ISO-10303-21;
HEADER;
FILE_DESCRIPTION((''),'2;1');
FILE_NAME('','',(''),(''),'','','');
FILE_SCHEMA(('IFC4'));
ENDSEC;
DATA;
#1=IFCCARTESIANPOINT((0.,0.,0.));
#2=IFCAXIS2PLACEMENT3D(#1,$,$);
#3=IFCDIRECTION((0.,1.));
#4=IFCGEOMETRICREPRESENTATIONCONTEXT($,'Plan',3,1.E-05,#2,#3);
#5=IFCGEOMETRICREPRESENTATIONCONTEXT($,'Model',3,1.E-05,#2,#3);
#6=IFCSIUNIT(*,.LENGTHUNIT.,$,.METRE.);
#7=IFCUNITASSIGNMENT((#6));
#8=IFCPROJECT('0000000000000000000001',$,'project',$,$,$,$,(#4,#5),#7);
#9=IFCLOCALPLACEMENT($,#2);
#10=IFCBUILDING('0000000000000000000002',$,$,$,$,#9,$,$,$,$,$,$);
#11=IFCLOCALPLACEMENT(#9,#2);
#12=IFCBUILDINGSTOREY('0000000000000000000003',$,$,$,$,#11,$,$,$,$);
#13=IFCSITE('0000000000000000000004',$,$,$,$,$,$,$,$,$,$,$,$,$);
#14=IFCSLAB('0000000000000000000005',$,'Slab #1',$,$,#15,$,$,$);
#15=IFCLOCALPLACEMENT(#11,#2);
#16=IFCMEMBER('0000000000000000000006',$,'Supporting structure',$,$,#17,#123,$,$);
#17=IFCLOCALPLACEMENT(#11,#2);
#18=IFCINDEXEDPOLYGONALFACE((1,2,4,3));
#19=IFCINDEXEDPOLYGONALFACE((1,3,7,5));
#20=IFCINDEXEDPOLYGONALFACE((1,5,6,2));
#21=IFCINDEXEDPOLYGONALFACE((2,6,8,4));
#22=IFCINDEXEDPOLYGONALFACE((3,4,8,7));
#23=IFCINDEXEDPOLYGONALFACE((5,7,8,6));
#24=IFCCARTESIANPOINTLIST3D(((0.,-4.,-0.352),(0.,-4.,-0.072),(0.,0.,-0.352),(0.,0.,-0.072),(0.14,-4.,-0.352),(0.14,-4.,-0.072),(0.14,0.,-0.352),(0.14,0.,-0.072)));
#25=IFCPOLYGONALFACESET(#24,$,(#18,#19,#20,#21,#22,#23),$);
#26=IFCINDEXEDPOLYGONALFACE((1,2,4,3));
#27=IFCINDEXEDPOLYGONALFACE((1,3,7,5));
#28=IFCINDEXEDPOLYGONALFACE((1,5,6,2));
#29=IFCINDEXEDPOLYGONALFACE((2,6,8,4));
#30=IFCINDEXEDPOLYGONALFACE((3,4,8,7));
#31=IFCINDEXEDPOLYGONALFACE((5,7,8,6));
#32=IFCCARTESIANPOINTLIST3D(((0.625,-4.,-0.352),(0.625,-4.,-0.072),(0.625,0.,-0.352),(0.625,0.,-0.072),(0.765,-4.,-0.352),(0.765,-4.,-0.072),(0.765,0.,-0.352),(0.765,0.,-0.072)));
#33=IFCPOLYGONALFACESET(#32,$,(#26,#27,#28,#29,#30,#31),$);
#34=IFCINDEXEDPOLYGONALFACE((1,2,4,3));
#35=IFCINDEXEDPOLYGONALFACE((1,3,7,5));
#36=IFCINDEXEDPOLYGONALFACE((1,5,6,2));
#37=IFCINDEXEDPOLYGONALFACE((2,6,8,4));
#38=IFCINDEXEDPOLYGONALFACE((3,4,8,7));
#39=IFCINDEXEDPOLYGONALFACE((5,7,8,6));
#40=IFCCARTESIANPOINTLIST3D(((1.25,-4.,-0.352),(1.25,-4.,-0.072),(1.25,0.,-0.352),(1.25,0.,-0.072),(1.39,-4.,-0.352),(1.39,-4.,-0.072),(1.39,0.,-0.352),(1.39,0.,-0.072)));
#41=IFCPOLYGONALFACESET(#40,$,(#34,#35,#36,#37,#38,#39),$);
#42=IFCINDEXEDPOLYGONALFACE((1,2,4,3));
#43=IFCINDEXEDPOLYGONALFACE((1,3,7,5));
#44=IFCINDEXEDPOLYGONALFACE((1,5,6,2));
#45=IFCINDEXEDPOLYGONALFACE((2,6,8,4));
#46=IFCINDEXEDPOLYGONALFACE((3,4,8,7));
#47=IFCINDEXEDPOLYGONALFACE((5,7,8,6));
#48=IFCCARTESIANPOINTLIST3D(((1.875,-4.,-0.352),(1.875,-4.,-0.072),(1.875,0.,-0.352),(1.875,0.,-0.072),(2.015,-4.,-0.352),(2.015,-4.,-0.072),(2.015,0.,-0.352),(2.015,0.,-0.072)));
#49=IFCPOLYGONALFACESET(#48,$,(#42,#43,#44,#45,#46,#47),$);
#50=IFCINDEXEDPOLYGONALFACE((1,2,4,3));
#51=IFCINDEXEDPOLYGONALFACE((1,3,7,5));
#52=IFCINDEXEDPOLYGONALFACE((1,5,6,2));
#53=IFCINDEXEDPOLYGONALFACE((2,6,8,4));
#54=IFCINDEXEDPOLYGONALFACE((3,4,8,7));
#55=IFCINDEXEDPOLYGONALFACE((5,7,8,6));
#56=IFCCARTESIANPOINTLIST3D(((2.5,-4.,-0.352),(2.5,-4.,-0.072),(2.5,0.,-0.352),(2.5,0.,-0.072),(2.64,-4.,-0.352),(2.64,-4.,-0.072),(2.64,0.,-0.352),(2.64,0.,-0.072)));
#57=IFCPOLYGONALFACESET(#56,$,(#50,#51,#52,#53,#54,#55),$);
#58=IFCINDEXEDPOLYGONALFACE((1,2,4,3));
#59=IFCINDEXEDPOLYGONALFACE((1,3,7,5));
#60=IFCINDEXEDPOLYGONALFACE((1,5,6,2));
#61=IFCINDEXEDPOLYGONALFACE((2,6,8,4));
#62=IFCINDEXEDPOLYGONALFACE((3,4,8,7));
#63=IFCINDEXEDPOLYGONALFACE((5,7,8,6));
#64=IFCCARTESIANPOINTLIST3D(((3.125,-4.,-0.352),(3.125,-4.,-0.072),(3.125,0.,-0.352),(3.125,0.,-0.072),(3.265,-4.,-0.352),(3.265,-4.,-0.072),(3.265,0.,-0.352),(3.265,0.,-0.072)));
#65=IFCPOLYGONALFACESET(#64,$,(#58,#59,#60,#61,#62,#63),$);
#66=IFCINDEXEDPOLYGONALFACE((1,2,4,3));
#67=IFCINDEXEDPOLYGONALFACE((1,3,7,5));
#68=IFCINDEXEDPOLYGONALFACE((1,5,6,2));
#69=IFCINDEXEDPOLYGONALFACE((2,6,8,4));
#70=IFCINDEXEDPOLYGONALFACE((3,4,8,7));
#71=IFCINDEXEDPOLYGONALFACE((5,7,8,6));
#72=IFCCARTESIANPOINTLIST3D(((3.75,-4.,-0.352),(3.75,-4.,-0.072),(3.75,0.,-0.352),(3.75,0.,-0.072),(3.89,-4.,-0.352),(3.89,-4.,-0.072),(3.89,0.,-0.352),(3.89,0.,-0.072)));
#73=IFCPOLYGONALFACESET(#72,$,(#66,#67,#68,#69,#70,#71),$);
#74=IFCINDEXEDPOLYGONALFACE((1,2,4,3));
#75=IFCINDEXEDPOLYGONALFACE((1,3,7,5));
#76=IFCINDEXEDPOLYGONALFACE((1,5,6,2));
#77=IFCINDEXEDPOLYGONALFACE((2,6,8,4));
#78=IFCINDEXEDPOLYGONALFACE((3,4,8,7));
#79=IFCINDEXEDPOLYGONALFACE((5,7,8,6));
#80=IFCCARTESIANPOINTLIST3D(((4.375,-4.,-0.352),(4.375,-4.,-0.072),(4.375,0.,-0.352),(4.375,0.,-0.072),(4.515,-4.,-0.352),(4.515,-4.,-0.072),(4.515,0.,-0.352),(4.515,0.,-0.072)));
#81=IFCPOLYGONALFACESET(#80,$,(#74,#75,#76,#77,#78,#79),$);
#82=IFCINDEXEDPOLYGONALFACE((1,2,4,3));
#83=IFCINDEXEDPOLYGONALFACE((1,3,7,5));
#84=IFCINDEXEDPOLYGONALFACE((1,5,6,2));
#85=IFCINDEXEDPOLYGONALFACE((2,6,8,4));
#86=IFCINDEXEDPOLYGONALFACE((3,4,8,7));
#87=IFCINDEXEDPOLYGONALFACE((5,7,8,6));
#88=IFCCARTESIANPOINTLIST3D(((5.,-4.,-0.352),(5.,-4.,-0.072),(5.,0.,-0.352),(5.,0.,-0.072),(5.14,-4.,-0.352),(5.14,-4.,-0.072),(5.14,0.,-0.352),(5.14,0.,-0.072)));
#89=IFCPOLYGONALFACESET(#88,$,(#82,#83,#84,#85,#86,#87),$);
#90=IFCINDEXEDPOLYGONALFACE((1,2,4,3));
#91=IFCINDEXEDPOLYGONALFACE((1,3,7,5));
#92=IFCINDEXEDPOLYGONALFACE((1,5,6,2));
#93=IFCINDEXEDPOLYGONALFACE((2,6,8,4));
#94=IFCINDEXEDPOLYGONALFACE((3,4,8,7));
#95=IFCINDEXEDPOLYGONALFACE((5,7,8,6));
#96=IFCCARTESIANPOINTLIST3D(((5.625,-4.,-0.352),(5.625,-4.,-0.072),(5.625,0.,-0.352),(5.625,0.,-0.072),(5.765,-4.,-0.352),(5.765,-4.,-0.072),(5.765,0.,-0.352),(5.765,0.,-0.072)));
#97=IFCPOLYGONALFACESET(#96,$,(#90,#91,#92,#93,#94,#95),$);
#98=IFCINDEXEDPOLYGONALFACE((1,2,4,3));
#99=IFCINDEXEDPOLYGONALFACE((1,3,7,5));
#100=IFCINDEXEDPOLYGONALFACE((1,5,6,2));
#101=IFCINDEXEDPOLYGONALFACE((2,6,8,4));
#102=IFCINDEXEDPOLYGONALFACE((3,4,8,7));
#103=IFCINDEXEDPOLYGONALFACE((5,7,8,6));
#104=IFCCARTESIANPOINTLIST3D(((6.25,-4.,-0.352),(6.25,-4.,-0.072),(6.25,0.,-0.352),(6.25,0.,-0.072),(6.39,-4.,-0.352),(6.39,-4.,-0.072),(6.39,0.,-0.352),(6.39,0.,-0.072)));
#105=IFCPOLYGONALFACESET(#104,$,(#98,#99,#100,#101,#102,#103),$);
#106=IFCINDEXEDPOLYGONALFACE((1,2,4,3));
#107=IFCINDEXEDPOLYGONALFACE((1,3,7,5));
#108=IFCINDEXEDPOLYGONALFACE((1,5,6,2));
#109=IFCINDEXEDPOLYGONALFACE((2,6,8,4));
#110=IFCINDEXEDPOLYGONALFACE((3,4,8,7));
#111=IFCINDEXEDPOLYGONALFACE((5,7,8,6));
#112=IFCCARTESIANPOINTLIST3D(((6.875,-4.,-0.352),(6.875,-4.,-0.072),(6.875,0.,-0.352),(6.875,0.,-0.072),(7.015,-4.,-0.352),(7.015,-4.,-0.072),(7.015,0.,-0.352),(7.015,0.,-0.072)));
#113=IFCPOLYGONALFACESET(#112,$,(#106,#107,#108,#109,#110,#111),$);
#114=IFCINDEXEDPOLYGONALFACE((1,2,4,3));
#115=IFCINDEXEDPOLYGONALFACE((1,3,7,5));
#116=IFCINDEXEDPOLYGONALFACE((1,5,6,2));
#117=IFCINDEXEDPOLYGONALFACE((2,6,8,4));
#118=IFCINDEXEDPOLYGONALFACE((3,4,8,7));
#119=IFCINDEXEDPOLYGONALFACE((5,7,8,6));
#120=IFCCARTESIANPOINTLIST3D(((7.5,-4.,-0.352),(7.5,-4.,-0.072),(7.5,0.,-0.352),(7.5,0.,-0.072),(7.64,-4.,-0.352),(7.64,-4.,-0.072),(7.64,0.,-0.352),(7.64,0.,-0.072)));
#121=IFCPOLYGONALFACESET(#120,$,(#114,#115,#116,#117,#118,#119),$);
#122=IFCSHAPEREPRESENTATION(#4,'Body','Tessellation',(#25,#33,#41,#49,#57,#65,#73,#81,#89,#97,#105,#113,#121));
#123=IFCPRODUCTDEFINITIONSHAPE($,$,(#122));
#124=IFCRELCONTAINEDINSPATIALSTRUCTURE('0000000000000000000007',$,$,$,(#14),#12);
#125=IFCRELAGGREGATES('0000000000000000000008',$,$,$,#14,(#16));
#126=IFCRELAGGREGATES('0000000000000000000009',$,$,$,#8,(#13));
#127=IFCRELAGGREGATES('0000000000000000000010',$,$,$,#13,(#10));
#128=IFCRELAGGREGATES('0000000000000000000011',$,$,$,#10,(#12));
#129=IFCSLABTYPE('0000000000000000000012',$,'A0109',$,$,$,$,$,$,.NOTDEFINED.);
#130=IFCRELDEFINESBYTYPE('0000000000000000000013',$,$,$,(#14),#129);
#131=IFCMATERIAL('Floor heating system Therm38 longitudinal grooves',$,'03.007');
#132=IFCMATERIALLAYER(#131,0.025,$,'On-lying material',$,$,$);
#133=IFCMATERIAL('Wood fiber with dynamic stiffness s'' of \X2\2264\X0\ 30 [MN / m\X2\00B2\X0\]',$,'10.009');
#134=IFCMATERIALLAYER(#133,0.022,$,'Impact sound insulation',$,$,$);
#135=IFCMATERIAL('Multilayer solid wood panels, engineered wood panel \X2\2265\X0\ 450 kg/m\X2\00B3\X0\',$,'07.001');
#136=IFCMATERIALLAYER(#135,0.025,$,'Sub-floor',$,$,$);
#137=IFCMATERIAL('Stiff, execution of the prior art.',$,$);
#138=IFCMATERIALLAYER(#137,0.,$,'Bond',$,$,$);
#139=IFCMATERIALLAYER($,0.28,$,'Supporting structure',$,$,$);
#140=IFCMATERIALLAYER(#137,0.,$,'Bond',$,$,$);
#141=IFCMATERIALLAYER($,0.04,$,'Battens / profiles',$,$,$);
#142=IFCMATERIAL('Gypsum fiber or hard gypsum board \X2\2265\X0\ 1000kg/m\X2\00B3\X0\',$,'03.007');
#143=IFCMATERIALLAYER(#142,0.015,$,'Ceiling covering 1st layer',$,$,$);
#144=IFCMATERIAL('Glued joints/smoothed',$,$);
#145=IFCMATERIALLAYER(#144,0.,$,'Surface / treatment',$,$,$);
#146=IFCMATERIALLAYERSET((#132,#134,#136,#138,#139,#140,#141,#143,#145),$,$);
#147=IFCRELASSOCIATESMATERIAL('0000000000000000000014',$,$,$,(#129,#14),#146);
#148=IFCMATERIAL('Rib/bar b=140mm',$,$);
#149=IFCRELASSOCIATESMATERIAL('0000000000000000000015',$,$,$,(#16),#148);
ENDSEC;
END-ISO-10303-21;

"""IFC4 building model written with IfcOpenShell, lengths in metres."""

from ifc_helpers import new_model, si_unit, direction, frame, frame_2d, origin, place, context, project, spatial, rectangle, extrude, material, layer, layer_set, type_object, element, aggregate, save


model = new_model("IFC4")

# Units and contexts
plan_context = context("Plan", 3, precision=1e-05, world=origin(), true_north=direction((0.0, 1.0)))
model_context = context("Model", 3, precision=1e-05, world=origin(), true_north=direction((0.0, 1.0)))
ifc_project = project(units=[si_unit("LENGTHUNIT", "METRE")], contexts=[plan_context, model_context])

# Site, building, storey
site = spatial("IfcSite", under=ifc_project)
building_placement = place(None, origin())
building = spatial("IfcBuilding", under=site, at=building_placement)
storey_placement = place(building_placement, origin())
storey = spatial("IfcBuildingStorey", under=building, at=storey_placement)

# Slab, member
ifc_material_1 = material(Name="Floor heating system Therm38 longitudinal grooves", Category="03.007")
ifc_layer_1 = layer(ifc_material_1, 0.025, Name="On-lying material")
ifc_material_2 = material(Name="Wood fiber with dynamic stiffness s' of ≤ 30 [MN / m²]", Category="10.009")
ifc_layer_2 = layer(ifc_material_2, 0.022, Name="Impact sound insulation")
ifc_material_3 = material(Name="Multilayer solid wood panels, engineered wood panel ≥ 450 kg/m³", Category="07.001")
ifc_layer_3 = layer(ifc_material_3, 0.025, Name="Sub-floor")
ifc_material_4 = material(Name="Stiff, execution of the prior art.")
ifc_layer_4 = layer(ifc_material_4, 0.0, Name="Bond")
ifc_layer_5 = layer(None, 0.28, Name="Supporting structure")
ifc_layer_6 = layer(ifc_material_4, 0.0, Name="Bond")
ifc_layer_7 = layer(None, 0.04, Name="Battens / profiles")
ifc_material_5 = material(Name="Gypsum fiber or hard gypsum board ≥ 1000kg/m³", Category="03.007")
ifc_layer_8 = layer(ifc_material_5, 0.015, Name="Ceiling covering 1st layer")
ifc_material_6 = material(Name="Glued joints/smoothed")
ifc_layer_9 = layer(ifc_material_6, 0.0, Name="Surface / treatment")
ifc_layer_set = layer_set([ifc_layer_1, ifc_layer_2, ifc_layer_3, ifc_layer_4, ifc_layer_5, ifc_layer_6, ifc_layer_7, ifc_layer_8, ifc_layer_9])
slab_type = type_object("IfcSlabType", Name="A0109", PredefinedType="NOTDEFINED", material=ifc_layer_set)
slab_placement = place(None, frame((0.0, 0.0, 0.0), z_axis=(0.0, 0.0, -1.0), x_axis=(1.0, 0.0, 0.0)))
slab = element("IfcSlab", 1, at=slab_placement, inside=storey, type_object=slab_type, material=ifc_layer_set, Name="Slab #1")
ifc_material_7 = material(Name="Rib/bar b=140mm")
member_1_placement = place(slab_placement, origin())
member_1 = element("IfcMember", 2, at=member_1_placement, material=ifc_material_7, Name="Supporting structure", context=plan_context, shape_type="SweptSolid", body=[
    extrude(rectangle(XDim=0.14, YDim=0.28, at=frame_2d((0.07, 0.14), x_axis=(1.0, 0.0))), frame((0.0, 4.0, 0.072), z_axis=(0.0, -1.0, 0.0), x_axis=(1.0, 0.0, 0.0)), (0.0, 0.0, 1.0), 4.0),
    extrude(rectangle(XDim=0.14, YDim=0.28, at=frame_2d((0.07, 0.14), x_axis=(1.0, 0.0))), frame((0.625, 4.0, 0.072), z_axis=(0.0, -1.0, 0.0), x_axis=(1.0, 0.0, 0.0)), (0.0, 0.0, 1.0), 4.0),
    extrude(rectangle(XDim=0.14, YDim=0.28, at=frame_2d((0.07, 0.14), x_axis=(1.0, 0.0))), frame((1.25, 4.0, 0.072), z_axis=(0.0, -1.0, 0.0), x_axis=(1.0, 0.0, 0.0)), (0.0, 0.0, 1.0), 4.0),
    extrude(rectangle(XDim=0.14, YDim=0.28, at=frame_2d((0.07, 0.14), x_axis=(1.0, 0.0))), frame((1.875, 4.0, 0.072), z_axis=(0.0, -1.0, 0.0), x_axis=(1.0, 0.0, 0.0)), (0.0, 0.0, 1.0), 4.0),
    extrude(rectangle(XDim=0.14, YDim=0.28, at=frame_2d((0.07, 0.14), x_axis=(1.0, 0.0))), frame((2.5, 4.0, 0.072), z_axis=(0.0, -1.0, 0.0), x_axis=(1.0, 0.0, 0.0)), (0.0, 0.0, 1.0), 4.0),
    extrude(rectangle(XDim=0.14, YDim=0.28, at=frame_2d((0.07, 0.14), x_axis=(1.0, 0.0))), frame((3.125, 4.0, 0.072), z_axis=(0.0, -1.0, 0.0), x_axis=(1.0, 0.0, 0.0)), (0.0, 0.0, 1.0), 4.0),
    extrude(rectangle(XDim=0.14, YDim=0.28, at=frame_2d((0.07, 0.14), x_axis=(1.0, 0.0))), frame((3.75, 4.0, 0.072), z_axis=(0.0, -1.0, 0.0), x_axis=(1.0, 0.0, 0.0)), (0.0, 0.0, 1.0), 4.0),
    extrude(rectangle(XDim=0.14, YDim=0.28, at=frame_2d((0.07, 0.14), x_axis=(1.0, 0.0))), frame((4.375, 4.0, 0.072), z_axis=(0.0, -1.0, 0.0), x_axis=(1.0, 0.0, 0.0)), (0.0, 0.0, 1.0), 4.0),
    extrude(rectangle(XDim=0.14, YDim=0.28, at=frame_2d((0.07, 0.14), x_axis=(1.0, 0.0))), frame((5.0, 4.0, 0.072), z_axis=(0.0, -1.0, 0.0), x_axis=(1.0, 0.0, 0.0)), (0.0, 0.0, 1.0), 4.0),
    extrude(rectangle(XDim=0.14, YDim=0.28, at=frame_2d((0.07, 0.14), x_axis=(1.0, 0.0))), frame((5.625, 4.0, 0.072), z_axis=(0.0, -1.0, 0.0), x_axis=(1.0, 0.0, 0.0)), (0.0, 0.0, 1.0), 4.0),
    extrude(rectangle(XDim=0.14, YDim=0.28, at=frame_2d((0.07, 0.14), x_axis=(1.0, 0.0))), frame((6.25, 4.0, 0.072), z_axis=(0.0, -1.0, 0.0), x_axis=(1.0, 0.0, 0.0)), (0.0, 0.0, 1.0), 4.0),
    extrude(rectangle(XDim=0.14, YDim=0.28, at=frame_2d((0.07, 0.14), x_axis=(1.0, 0.0))), frame((6.875, 4.0, 0.072), z_axis=(0.0, -1.0, 0.0), x_axis=(1.0, 0.0, 0.0)), (0.0, 0.0, 1.0), 4.0),
    extrude(rectangle(XDim=0.14, YDim=0.28, at=frame_2d((0.07, 0.14), x_axis=(1.0, 0.0))), frame((7.5, 4.0, 0.072), z_axis=(0.0, -1.0, 0.0), x_axis=(1.0, 0.0, 0.0)), (0.0, 0.0, 1.0), 4.0),
])
aggregate(slab, [member_1])

save(model, "model.ifc")
